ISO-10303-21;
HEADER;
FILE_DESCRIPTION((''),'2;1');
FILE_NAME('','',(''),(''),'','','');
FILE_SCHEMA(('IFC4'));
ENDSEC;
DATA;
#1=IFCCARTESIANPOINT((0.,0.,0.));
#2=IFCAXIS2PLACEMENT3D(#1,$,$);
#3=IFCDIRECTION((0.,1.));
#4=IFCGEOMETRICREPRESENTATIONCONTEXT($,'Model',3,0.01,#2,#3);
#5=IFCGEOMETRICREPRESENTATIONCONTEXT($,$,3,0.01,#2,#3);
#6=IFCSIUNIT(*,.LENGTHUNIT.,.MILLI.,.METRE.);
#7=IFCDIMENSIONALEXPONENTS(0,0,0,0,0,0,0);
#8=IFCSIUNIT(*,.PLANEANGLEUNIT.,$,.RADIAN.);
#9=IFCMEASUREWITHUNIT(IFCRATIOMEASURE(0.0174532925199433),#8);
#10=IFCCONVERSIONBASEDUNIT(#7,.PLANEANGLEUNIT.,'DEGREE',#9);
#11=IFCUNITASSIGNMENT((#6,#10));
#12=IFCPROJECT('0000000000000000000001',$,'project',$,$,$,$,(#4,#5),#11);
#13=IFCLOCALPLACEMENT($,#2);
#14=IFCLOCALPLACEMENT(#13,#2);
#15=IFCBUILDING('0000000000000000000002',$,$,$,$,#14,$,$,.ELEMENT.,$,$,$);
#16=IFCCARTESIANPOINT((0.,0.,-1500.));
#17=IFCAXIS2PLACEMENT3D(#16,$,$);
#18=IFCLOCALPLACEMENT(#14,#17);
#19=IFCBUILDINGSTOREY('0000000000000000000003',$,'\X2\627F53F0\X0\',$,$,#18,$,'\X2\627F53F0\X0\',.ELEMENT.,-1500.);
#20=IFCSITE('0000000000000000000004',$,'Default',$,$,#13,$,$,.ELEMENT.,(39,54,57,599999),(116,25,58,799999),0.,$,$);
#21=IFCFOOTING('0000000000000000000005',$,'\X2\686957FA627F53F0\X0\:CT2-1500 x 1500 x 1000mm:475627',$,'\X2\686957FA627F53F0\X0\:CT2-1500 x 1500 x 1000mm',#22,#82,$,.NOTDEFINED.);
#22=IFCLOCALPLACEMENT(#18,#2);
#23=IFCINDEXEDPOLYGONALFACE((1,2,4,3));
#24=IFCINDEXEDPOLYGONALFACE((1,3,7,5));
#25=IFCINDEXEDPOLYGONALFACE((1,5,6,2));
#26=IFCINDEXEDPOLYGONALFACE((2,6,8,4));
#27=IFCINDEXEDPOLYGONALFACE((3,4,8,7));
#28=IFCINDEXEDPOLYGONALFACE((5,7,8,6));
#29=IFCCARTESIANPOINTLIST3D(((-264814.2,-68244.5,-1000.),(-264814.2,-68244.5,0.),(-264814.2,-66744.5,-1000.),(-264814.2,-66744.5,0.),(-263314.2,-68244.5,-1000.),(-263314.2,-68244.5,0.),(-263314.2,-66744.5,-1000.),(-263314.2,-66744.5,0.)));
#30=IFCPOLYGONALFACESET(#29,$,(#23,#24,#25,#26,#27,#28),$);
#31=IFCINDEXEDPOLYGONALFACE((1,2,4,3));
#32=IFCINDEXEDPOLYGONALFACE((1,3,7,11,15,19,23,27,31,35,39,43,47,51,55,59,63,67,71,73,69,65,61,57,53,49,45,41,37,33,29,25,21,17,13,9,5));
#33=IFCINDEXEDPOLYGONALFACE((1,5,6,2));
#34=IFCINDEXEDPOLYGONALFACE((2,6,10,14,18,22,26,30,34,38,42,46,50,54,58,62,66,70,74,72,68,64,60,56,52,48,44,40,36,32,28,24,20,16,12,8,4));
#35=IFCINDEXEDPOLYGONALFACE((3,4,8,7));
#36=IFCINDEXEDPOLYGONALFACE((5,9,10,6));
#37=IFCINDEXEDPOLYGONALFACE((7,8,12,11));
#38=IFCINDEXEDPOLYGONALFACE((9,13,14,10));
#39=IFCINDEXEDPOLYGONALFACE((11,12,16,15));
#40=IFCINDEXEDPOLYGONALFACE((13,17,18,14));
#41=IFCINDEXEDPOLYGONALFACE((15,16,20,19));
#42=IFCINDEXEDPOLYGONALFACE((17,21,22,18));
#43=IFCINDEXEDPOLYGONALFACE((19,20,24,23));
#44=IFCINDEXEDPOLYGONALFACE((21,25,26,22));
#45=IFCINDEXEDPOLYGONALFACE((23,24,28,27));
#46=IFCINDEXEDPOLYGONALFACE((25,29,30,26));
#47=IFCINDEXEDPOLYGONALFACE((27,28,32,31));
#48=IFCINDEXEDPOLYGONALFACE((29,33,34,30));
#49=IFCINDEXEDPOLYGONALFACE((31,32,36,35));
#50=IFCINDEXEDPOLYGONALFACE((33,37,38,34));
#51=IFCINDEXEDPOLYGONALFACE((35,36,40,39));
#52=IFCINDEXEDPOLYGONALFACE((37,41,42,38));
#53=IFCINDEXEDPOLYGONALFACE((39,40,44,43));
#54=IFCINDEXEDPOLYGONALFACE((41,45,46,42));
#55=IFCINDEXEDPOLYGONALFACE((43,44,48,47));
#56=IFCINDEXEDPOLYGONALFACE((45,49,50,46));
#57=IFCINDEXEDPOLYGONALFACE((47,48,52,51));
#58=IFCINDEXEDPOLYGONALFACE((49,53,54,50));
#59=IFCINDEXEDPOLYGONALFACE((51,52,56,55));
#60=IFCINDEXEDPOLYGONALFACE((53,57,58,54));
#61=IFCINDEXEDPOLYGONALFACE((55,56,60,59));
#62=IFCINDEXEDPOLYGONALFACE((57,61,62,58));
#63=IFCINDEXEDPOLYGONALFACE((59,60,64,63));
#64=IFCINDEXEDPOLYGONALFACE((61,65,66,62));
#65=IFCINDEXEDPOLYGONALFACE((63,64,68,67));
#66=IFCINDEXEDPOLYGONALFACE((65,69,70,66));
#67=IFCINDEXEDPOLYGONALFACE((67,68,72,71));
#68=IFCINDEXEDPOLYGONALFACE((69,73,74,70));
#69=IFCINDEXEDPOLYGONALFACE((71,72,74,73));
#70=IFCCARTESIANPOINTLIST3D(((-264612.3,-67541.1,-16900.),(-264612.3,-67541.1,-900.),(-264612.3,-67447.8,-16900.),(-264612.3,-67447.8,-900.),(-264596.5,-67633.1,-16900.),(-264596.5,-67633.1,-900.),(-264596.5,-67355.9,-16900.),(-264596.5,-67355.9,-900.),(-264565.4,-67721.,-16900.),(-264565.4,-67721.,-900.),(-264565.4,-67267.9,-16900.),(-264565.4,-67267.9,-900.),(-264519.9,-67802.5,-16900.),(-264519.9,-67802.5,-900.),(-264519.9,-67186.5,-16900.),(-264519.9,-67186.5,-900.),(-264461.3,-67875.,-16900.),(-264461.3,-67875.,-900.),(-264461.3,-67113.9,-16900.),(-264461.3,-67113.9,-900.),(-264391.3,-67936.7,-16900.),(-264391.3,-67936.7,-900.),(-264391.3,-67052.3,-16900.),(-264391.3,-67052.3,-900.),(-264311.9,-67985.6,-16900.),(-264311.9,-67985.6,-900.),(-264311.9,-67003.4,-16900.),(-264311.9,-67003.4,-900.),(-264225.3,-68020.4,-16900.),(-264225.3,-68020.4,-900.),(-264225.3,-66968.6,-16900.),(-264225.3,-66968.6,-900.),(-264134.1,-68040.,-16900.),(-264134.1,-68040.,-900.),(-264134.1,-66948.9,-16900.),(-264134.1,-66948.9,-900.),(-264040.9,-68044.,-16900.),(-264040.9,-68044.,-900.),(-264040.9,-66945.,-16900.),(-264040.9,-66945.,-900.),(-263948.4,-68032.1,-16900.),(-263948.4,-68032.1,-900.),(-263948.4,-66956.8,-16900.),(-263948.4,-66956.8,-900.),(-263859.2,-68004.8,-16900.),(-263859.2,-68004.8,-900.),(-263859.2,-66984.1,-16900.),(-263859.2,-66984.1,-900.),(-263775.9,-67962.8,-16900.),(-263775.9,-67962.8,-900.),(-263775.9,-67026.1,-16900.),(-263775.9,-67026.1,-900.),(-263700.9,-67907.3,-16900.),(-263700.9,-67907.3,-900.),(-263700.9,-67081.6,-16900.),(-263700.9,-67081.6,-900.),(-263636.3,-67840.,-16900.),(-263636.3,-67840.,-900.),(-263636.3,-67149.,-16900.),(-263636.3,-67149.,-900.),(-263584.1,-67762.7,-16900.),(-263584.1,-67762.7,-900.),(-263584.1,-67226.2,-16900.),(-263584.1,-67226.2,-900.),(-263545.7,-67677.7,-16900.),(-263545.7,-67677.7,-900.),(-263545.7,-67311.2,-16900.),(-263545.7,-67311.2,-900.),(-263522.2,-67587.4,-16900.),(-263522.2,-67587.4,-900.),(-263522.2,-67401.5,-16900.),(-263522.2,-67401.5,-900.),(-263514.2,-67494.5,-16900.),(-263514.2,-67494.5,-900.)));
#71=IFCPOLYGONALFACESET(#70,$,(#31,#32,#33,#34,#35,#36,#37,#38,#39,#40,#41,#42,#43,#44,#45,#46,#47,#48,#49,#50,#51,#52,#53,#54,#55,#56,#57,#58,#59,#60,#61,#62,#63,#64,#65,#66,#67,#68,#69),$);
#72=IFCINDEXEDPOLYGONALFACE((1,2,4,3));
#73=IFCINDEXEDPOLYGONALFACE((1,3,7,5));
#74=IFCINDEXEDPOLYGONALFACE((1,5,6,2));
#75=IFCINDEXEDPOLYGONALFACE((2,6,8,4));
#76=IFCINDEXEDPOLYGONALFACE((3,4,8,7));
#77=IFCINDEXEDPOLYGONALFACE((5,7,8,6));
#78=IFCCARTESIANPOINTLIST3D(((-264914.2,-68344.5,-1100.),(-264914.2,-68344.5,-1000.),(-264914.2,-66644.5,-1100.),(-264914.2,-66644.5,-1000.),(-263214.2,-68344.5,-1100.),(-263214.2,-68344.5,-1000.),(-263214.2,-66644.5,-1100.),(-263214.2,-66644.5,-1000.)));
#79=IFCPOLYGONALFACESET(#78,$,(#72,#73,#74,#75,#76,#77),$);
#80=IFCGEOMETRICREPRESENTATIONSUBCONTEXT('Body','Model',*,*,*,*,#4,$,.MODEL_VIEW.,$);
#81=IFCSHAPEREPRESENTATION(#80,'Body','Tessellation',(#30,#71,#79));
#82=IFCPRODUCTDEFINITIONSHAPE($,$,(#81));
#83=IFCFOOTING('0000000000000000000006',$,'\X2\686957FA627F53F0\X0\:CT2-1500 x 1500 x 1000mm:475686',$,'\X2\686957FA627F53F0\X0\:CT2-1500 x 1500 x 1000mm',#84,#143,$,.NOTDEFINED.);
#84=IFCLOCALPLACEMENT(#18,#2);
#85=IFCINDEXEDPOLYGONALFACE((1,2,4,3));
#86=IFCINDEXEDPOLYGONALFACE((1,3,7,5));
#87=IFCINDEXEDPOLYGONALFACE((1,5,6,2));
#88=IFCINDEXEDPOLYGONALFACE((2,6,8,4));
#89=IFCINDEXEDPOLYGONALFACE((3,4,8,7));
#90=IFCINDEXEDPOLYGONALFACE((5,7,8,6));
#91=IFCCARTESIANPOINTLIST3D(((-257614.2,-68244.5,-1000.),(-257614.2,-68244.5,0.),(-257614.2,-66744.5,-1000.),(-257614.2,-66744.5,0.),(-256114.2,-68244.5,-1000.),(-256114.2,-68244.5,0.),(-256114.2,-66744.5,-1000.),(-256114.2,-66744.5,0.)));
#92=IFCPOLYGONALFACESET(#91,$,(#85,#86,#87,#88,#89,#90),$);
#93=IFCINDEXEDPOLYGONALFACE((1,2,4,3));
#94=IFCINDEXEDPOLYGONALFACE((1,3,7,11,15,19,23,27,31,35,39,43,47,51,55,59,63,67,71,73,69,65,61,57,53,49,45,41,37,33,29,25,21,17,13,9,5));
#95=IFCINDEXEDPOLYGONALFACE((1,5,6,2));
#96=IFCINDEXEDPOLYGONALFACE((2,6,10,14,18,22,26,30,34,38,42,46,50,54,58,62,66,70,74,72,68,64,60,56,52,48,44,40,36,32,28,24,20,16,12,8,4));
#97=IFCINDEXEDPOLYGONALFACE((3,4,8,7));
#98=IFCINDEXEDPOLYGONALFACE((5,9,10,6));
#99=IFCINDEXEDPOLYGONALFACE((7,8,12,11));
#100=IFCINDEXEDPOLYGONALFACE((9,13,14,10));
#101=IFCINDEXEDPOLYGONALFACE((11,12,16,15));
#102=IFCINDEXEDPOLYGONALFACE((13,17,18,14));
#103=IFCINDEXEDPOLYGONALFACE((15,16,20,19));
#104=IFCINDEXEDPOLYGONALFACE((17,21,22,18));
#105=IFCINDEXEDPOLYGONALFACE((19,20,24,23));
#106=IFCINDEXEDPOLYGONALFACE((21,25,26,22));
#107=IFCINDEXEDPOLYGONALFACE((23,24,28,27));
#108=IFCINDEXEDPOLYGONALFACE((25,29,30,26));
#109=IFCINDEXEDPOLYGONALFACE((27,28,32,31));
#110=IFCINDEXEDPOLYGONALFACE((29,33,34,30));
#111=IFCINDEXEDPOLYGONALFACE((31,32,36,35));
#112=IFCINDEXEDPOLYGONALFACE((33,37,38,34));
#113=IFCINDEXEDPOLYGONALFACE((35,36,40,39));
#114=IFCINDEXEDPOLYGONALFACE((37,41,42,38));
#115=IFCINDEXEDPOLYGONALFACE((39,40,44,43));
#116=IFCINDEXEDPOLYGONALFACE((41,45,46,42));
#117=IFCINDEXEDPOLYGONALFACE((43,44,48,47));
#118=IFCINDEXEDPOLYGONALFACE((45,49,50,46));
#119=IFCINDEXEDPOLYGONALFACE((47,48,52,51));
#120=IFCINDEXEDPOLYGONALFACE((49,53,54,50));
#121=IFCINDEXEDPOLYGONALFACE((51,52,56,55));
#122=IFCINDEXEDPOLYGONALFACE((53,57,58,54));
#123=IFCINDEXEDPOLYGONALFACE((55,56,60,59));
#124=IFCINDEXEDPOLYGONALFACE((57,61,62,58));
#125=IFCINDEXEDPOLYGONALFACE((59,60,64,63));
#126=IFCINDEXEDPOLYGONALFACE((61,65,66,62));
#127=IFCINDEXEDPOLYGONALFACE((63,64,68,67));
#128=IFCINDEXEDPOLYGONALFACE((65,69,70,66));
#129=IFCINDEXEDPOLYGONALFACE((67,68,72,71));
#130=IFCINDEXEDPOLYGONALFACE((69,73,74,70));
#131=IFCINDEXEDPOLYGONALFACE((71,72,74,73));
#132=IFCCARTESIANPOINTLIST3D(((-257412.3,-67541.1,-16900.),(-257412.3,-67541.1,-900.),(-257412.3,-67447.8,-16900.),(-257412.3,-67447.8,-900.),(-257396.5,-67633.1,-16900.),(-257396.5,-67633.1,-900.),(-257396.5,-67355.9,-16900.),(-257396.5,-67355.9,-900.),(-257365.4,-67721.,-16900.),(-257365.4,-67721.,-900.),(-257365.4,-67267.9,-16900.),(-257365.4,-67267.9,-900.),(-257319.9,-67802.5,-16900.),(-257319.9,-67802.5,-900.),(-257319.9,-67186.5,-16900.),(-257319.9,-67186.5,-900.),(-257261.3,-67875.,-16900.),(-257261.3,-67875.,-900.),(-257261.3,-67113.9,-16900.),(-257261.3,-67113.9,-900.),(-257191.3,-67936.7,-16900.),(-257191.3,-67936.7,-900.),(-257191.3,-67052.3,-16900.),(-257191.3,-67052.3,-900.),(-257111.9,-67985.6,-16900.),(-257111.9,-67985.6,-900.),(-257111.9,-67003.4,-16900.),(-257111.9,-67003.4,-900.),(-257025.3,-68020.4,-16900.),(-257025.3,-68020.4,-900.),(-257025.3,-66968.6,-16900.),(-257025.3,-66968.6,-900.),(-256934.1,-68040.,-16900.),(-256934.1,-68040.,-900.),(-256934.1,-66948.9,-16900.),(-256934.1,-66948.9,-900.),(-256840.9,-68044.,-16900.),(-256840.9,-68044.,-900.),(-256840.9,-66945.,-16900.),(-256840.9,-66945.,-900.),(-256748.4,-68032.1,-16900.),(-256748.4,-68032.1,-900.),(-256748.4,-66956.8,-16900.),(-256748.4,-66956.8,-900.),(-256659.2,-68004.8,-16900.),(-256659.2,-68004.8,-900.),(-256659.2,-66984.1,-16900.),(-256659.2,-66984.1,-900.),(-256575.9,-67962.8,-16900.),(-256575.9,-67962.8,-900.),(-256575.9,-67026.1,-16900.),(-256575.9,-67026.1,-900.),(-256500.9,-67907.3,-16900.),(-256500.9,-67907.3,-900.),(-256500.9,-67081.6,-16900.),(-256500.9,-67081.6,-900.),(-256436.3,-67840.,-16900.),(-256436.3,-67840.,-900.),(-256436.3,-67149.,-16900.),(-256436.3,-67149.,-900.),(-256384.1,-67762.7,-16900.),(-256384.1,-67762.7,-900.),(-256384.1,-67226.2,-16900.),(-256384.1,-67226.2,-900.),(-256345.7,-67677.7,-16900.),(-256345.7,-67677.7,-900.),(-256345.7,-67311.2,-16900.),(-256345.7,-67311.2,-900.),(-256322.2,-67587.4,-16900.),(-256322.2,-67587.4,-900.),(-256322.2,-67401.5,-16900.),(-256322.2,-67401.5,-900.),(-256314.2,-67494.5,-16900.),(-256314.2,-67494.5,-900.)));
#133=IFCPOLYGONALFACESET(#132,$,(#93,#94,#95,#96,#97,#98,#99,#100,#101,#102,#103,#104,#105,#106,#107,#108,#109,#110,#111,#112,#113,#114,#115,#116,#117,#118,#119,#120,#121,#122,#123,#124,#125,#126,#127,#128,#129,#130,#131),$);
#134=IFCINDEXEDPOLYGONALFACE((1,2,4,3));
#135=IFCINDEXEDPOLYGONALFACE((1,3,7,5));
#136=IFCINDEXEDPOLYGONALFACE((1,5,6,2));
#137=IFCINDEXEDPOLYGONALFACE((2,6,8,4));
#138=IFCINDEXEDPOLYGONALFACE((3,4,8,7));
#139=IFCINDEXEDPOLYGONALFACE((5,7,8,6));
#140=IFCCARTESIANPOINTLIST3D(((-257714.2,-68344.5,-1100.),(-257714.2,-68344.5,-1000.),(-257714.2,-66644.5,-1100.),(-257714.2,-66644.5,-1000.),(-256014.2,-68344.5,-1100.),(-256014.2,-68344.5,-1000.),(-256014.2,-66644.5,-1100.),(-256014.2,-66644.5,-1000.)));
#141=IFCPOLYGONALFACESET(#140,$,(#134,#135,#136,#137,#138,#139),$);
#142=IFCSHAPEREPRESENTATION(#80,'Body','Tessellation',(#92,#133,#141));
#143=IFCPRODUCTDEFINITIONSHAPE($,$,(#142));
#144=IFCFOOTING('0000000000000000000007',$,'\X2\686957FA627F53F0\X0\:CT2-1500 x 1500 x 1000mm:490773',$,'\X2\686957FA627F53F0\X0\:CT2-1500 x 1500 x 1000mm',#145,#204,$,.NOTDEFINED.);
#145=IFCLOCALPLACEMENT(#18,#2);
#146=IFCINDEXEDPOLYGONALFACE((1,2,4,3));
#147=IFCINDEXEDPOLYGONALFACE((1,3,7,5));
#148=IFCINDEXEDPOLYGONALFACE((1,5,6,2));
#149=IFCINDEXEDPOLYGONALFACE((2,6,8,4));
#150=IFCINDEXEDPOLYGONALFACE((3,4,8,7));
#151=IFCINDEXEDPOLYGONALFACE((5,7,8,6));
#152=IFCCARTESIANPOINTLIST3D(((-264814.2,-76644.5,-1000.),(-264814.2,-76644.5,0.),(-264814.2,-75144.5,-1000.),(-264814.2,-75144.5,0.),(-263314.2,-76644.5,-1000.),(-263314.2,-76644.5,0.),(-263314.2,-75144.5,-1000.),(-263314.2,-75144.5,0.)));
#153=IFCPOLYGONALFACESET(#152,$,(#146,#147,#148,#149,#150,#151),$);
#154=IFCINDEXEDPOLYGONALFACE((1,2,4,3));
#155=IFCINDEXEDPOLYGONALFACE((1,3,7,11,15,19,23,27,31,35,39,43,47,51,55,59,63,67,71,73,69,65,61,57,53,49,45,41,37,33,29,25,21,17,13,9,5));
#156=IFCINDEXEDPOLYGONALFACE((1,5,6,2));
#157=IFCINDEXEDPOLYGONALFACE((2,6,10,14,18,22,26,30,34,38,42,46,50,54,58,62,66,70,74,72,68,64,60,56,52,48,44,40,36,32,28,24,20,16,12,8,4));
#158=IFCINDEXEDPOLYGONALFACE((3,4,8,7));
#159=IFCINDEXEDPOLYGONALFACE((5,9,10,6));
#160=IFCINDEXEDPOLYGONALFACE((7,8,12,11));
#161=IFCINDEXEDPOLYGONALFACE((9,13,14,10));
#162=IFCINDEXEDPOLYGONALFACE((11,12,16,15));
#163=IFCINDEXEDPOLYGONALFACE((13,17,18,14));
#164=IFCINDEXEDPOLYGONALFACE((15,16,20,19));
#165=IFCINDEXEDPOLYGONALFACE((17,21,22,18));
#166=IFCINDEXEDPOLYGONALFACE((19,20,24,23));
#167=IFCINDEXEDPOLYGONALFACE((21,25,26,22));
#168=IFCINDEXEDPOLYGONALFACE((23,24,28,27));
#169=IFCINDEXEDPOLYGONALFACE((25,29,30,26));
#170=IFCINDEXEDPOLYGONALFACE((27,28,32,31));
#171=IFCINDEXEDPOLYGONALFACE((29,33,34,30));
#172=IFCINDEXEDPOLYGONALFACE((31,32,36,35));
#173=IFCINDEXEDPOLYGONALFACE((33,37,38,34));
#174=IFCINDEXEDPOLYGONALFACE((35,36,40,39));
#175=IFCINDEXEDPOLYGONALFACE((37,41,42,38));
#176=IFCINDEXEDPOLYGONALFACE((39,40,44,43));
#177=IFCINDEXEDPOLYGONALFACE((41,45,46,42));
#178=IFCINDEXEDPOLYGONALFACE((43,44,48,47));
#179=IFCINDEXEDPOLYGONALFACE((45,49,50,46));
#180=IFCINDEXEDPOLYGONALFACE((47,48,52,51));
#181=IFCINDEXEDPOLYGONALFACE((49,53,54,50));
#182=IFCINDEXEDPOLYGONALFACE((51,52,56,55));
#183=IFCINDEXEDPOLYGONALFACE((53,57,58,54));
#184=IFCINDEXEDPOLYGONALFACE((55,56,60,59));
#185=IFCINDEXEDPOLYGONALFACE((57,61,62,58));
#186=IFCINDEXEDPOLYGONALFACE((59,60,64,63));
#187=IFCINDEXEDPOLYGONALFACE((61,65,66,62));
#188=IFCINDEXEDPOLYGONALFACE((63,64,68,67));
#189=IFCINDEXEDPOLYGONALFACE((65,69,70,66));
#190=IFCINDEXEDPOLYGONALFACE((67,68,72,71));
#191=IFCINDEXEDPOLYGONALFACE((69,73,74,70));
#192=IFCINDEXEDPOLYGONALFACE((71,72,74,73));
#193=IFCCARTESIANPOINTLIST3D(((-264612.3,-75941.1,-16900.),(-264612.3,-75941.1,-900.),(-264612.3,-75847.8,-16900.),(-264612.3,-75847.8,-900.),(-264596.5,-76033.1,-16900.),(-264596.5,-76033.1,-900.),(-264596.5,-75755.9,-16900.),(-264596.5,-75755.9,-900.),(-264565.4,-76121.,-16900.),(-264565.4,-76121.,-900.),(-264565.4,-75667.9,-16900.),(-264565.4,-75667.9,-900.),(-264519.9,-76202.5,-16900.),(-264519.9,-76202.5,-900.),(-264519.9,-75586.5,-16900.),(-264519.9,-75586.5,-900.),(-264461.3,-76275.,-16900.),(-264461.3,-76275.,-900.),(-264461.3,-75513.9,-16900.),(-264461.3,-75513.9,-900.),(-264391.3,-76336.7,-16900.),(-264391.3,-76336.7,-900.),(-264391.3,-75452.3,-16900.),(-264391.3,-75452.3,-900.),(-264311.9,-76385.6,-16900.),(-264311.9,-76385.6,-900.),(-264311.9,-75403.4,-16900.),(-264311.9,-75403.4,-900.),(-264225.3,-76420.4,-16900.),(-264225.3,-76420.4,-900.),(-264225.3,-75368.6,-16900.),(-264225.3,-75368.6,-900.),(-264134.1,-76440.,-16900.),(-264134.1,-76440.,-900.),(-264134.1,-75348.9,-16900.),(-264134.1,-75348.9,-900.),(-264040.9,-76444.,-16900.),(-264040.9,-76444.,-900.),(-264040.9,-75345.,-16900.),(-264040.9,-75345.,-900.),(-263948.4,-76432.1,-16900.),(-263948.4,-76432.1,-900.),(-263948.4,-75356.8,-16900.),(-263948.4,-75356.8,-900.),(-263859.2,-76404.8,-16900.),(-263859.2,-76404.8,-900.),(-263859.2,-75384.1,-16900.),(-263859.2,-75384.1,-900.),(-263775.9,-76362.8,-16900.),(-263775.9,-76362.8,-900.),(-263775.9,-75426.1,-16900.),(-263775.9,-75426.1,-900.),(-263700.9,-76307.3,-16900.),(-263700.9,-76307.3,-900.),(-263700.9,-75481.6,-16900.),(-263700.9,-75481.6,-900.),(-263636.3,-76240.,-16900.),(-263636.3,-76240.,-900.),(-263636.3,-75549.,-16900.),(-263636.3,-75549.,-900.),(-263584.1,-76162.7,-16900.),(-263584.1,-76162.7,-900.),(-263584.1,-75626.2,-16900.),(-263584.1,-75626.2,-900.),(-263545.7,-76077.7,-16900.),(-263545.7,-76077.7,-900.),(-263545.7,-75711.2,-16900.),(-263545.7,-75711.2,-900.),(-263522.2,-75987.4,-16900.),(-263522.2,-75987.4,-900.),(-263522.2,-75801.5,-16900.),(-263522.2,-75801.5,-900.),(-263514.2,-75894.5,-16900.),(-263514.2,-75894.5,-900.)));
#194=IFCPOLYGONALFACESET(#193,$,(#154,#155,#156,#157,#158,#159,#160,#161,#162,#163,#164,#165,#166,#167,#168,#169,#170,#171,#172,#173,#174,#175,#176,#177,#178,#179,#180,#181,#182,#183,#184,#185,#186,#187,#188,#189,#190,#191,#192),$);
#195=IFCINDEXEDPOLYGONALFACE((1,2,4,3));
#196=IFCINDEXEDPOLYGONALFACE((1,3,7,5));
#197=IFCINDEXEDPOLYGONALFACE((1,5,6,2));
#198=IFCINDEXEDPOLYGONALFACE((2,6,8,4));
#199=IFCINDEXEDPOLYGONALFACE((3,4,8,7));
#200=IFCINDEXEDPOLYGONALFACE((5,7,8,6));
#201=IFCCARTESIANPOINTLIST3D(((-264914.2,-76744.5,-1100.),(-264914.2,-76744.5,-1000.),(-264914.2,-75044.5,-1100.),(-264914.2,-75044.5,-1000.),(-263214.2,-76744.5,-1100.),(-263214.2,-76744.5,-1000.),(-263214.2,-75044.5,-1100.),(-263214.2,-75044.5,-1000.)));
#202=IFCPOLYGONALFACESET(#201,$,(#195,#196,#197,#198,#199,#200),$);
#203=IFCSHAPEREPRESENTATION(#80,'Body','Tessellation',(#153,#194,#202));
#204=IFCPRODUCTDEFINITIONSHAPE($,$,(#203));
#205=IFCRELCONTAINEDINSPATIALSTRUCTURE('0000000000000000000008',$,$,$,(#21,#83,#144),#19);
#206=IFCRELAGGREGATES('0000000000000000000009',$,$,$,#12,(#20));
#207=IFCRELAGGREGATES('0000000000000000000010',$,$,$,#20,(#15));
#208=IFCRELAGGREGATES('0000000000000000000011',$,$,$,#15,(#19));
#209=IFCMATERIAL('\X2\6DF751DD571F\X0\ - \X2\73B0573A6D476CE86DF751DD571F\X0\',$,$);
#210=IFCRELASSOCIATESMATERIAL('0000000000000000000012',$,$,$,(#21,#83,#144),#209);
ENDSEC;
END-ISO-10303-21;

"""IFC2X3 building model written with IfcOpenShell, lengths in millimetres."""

from ifc_helpers import new_model, entity, si_unit, converted_unit, direction, frame, frame_2d, origin, origin_2d_with_axis, place, context, subcontext, project, spatial, rectangle, circle, extrude, material, element, save


model = new_model("IFC2X3")

# Units and contexts
model_context = context("Model", 3, precision=0.01, world=origin(), true_north=direction((0.0, 1.0)))
context_of_model = context(None, 3, precision=0.01, world=origin(), true_north=direction((0.0, 1.0)))
body_context = subcontext(model_context, "Body", "Model", "MODEL_VIEW")
ifc_project = project(units=[si_unit("LENGTHUNIT", "METRE", prefix="MILLI"), converted_unit("PLANEANGLEUNIT", "DEGREE", entity("IfcRatioMeasure", 0.0174532925199433), si_unit("PLANEANGLEUNIT", "RADIAN"), dimensions=[0, 0, 0, 0, 0, 0, 0])], contexts=[model_context, context_of_model])

# Site, building, storey
site_placement = place(None, origin())
site = spatial("IfcSite", under=ifc_project, at=site_placement, Name="Default", CompositionType="ELEMENT", RefLatitude=(39, 54, 57, 599999), RefLongitude=(116, 25, 58, 799999), RefElevation=0.0)
building_placement = place(site_placement, origin())
building = spatial("IfcBuilding", under=site, at=building_placement, CompositionType="ELEMENT")
storey_placement = place(building_placement, frame((0.0, 0.0, -1500.0)))
storey = spatial("IfcBuildingStorey", under=building, at=storey_placement, Name="承台", LongName="承台", CompositionType="ELEMENT", Elevation=-1500.0)

# Footings
ifc_material_1 = material(Name="混凝土 - 现场浇注混凝土")
footing_1_placement = place(storey_placement, frame((-264914.2, -68344.5, -16900.0)))
element("IfcFooting", 1, at=footing_1_placement, inside=storey, material=ifc_material_1, Name="桩基承台:CT2-1500 x 1500 x 1000mm:475627", ObjectType="桩基承台:CT2-1500 x 1500 x 1000mm", PredefinedType="NOTDEFINED", context=body_context, shape_type="SweptSolid", body=[
    extrude(rectangle(XDim=1500.0, YDim=1500.0, at=frame_2d((0.0, 0.0), x_axis=(1.0, 0.0))), frame((850.0, 850.0, 15900.0), z_axis=(0.0, 0.0, 1.0), x_axis=(-1.0, 0.0, 0.0)), (0.0, 0.0, 1.0), 1000.0),
    extrude(circle(Radius=550.0, at=origin_2d_with_axis()), frame((850.0, 850.0, 0.0)), (0.0, 0.0, 1.0), 16000.0),
    extrude(rectangle(XDim=1700.0, YDim=1700.0, at=frame_2d((0.0, 0.0), x_axis=(1.0, 0.0))), frame((850.0, 850.0, 15800.0), z_axis=(0.0, 0.0, 1.0), x_axis=(0.0, 1.0, 0.0)), (0.0, 0.0, 1.0), 100.0),
])
footing_2_placement = place(storey_placement, frame((-257714.2, -68344.5, -16900.0)))
element("IfcFooting", 2, at=footing_2_placement, inside=storey, material=ifc_material_1, Name="桩基承台:CT2-1500 x 1500 x 1000mm:475686", ObjectType="桩基承台:CT2-1500 x 1500 x 1000mm", PredefinedType="NOTDEFINED", context=body_context, shape_type="SweptSolid", body=[
    extrude(rectangle(XDim=1500.0, YDim=1500.0, at=frame_2d((0.0, 0.0), x_axis=(1.0, 0.0))), frame((850.0, 850.0, 15900.0), z_axis=(0.0, 0.0, 1.0), x_axis=(-1.0, 0.0, 0.0)), (0.0, 0.0, 1.0), 1000.0),
    extrude(circle(Radius=550.0, at=origin_2d_with_axis()), frame((850.0, 850.0, 0.0)), (0.0, 0.0, 1.0), 16000.0),
    extrude(rectangle(XDim=1700.0, YDim=1700.0, at=frame_2d((0.0, 0.0), x_axis=(1.0, 0.0))), frame((850.0, 850.0, 15800.0), z_axis=(0.0, 0.0, 1.0), x_axis=(0.0, 1.0, 0.0)), (0.0, 0.0, 1.0), 100.0),
])
footing_3_placement = place(storey_placement, frame((-264914.2, -76744.5, -16900.0)))
element("IfcFooting", 3, at=footing_3_placement, inside=storey, material=ifc_material_1, Name="桩基承台:CT2-1500 x 1500 x 1000mm:490773", ObjectType="桩基承台:CT2-1500 x 1500 x 1000mm", PredefinedType="NOTDEFINED", context=body_context, shape_type="SweptSolid", body=[
    extrude(rectangle(XDim=1500.0, YDim=1500.0, at=frame_2d((0.0, 0.0), x_axis=(1.0, 0.0))), frame((850.0, 850.0, 15900.0), z_axis=(0.0, 0.0, 1.0), x_axis=(-1.0, 0.0, 0.0)), (0.0, 0.0, 1.0), 1000.0),
    extrude(circle(Radius=550.0, at=origin_2d_with_axis()), frame((850.0, 850.0, 0.0)), (0.0, 0.0, 1.0), 16000.0),
    extrude(rectangle(XDim=1700.0, YDim=1700.0, at=frame_2d((0.0, 0.0), x_axis=(1.0, 0.0))), frame((850.0, 850.0, 15800.0), z_axis=(0.0, 0.0, 1.0), x_axis=(0.0, 1.0, 0.0)), (0.0, 0.0, 1.0), 100.0),
])

save(model, "model.ifc")
